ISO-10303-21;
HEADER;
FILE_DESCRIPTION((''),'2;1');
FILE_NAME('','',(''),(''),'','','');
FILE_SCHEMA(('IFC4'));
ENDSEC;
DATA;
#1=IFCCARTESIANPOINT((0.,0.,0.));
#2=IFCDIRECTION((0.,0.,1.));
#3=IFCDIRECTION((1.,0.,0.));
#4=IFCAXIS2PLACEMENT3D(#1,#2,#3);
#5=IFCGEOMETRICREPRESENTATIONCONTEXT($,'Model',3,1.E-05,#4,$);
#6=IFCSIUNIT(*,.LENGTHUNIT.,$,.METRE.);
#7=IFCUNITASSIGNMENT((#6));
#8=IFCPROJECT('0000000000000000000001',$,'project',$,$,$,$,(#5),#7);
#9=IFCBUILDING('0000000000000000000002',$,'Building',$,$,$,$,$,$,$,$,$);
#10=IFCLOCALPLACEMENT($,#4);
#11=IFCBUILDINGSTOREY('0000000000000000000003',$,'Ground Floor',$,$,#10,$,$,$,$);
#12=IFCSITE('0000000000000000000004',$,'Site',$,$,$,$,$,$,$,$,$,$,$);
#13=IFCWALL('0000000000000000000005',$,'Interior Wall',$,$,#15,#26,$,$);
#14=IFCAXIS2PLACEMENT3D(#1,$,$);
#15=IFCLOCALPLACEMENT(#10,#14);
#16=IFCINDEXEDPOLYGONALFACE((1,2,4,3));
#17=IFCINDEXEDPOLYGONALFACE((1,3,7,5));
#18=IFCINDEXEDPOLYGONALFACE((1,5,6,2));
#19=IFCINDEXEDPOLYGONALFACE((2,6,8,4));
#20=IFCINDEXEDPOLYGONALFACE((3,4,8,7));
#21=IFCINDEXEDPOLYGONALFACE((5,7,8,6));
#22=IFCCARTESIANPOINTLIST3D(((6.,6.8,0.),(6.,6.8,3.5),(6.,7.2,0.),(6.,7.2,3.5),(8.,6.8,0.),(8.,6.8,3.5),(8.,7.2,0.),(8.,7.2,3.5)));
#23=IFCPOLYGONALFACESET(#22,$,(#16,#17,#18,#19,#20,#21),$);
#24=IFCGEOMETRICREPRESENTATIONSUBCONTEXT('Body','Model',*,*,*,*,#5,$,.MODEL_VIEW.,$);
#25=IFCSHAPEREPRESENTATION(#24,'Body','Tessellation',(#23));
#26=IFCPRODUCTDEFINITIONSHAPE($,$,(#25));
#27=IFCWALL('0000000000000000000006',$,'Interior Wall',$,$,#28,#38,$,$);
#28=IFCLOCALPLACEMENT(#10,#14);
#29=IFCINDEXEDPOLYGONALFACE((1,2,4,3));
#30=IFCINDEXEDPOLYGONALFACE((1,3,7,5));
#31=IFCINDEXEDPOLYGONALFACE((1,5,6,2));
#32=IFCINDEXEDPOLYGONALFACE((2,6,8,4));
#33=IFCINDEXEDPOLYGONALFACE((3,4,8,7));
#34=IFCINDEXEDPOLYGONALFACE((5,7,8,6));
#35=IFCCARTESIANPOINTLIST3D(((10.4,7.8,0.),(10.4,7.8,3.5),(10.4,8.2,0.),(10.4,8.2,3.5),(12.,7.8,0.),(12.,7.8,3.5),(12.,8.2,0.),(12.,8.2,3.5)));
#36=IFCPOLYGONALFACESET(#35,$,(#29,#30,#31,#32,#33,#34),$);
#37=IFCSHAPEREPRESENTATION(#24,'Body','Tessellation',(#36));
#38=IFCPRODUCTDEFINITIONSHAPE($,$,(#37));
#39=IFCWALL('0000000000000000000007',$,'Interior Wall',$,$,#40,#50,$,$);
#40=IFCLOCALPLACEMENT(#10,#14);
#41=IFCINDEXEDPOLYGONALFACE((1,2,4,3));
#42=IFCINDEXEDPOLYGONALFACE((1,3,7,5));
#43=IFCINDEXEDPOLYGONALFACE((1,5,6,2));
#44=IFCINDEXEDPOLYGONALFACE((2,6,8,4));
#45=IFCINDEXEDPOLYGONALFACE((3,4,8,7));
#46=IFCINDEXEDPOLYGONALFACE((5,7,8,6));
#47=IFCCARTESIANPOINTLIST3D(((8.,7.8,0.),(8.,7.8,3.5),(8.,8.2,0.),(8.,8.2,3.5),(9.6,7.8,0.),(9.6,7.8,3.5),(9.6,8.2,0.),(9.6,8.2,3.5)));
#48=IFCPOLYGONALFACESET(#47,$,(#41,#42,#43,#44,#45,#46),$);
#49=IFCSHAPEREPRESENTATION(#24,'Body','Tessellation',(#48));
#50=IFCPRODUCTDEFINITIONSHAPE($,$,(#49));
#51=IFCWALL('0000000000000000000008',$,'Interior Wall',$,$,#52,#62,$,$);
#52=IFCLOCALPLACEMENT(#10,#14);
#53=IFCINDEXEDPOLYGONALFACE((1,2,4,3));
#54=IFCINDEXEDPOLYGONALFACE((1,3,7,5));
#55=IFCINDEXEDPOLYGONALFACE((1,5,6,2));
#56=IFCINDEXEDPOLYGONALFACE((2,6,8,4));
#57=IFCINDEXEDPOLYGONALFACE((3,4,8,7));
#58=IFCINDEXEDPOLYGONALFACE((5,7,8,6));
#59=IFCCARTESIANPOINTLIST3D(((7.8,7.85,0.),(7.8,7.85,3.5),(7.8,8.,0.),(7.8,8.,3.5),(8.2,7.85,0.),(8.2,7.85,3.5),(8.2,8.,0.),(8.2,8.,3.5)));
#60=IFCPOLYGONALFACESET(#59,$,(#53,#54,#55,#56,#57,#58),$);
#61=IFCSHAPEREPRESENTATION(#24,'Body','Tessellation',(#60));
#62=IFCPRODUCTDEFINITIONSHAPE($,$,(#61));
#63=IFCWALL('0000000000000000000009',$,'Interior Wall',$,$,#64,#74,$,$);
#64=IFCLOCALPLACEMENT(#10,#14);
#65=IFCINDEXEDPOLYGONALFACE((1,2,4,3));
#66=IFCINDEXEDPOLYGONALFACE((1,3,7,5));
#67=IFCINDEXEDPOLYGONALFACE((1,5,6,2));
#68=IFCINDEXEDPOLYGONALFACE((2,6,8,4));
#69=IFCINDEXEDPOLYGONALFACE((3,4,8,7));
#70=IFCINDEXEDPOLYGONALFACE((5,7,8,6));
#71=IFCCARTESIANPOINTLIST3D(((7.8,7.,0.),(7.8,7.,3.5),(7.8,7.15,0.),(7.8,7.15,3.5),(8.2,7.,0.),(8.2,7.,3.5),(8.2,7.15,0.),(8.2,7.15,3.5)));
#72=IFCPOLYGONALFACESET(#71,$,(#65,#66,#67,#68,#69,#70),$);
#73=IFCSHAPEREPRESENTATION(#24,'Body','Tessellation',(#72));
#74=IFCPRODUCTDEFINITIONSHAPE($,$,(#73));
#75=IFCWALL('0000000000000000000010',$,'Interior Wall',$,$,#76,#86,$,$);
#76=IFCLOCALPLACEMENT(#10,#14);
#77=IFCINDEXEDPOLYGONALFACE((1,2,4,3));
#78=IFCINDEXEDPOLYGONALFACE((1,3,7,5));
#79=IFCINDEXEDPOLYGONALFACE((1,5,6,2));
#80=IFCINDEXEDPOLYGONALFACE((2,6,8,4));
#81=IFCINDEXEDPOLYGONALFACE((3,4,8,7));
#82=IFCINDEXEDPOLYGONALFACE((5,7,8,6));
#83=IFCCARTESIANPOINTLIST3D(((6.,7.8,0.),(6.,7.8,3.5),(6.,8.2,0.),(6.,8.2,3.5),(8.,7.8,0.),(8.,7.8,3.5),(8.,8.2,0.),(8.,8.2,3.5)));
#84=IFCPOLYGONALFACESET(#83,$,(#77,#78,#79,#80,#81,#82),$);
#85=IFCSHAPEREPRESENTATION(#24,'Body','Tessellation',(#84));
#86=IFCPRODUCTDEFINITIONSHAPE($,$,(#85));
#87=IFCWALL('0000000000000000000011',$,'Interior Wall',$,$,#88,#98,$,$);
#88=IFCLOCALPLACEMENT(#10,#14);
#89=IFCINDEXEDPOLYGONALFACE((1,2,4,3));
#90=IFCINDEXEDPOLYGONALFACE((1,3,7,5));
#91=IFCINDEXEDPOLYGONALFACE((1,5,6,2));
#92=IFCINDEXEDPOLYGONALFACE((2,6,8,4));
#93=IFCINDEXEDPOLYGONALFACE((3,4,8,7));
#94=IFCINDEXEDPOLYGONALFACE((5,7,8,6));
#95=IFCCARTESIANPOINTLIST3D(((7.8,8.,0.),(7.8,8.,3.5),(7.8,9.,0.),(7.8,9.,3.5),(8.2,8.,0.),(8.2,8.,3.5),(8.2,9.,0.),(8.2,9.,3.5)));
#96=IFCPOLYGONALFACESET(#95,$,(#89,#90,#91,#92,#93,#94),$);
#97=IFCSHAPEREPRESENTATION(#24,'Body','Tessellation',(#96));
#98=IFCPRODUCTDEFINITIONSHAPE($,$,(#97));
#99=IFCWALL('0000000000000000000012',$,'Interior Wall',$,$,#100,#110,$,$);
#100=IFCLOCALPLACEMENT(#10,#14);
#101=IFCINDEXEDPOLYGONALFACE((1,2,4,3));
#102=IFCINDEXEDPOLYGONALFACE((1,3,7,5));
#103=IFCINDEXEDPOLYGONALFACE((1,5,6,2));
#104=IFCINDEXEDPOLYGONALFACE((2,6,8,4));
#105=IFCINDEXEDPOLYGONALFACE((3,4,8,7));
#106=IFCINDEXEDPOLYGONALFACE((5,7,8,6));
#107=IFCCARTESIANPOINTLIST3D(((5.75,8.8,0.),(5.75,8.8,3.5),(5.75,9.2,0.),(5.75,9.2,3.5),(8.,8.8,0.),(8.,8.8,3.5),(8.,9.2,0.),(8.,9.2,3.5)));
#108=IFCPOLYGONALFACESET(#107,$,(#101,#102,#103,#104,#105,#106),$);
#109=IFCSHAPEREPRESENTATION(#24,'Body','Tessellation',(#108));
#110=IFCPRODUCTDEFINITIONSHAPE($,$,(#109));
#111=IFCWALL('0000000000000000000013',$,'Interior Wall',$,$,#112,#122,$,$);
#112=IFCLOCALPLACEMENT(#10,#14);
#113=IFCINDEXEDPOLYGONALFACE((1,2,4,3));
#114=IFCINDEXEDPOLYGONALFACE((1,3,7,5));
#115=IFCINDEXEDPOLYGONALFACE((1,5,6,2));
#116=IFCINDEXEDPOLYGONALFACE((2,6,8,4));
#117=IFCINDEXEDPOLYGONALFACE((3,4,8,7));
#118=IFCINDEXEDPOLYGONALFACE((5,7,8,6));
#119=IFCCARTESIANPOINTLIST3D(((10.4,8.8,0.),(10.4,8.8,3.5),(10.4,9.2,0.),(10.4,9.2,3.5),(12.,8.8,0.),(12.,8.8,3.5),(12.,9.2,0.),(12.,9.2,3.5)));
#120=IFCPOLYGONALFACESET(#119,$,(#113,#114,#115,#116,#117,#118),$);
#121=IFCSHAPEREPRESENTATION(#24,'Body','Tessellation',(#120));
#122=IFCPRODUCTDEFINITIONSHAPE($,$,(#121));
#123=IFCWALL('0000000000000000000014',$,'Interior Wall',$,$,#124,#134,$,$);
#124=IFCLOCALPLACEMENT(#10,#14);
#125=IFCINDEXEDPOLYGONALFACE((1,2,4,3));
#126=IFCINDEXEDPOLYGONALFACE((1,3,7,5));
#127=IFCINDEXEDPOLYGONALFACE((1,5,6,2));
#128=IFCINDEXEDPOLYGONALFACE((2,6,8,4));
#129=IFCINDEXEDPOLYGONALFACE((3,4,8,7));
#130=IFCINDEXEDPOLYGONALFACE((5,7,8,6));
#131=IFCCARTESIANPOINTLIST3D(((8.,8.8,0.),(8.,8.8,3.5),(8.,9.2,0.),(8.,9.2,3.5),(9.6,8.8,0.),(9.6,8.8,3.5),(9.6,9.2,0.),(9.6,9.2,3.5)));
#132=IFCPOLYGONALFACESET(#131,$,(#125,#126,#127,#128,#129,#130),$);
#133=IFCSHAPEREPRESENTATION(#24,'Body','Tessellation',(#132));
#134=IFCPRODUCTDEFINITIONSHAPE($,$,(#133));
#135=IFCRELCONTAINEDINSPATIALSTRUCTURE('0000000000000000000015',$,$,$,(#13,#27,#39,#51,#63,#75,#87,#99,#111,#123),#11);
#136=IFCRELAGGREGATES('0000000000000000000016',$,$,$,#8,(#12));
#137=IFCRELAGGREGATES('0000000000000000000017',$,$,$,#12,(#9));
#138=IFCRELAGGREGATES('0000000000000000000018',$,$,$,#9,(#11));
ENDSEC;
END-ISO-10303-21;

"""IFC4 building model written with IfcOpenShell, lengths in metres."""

from ifc_helpers import new_model, si_unit, frame, origin_with_axes, place, context, subcontext, project, spatial, indexed_curve, outline, extrude, element, save


model = new_model("IFC4")

# Units and contexts
model_context = context("Model", 3, precision=1e-05, world=origin_with_axes())
body_context = subcontext(model_context, "Body", "Model", "MODEL_VIEW")
ifc_project = project(units=[si_unit("LENGTHUNIT", "METRE")], contexts=[model_context])

# Site, building, storey
site = spatial("IfcSite", under=ifc_project, Name="Site")
building = spatial("IfcBuilding", under=site, Name="Building")
storey_placement = place(None, origin_with_axes())
storey = spatial("IfcBuildingStorey", under=building, at=storey_placement, Name="Ground Floor")

# Walls
for number, where, z_axis, x_axis, name in (
    (1, (8.0, 7.0, 0.0), (0.0, 0.0, 1.0), (-1.0, 0.0, 0.0), "Interior Wall"),
):
    element("IfcWall", number, at=place(storey_placement, frame(where, z_axis=z_axis, x_axis=x_axis)), inside=storey, Name=name, context=body_context, shape_type="SweptSolid", body=[
        extrude(outline(indexed_curve([(0.0, 0.0), (0.0, 0.4), (2.0, 0.4), (2.0, 0.0), (0.0, 0.0)], self_intersect=False)), frame((0.0, -0.2, 0.0), z_axis=(0.0, 0.0, 1.0), x_axis=(1.0, 0.0, 0.0)), (0.0, 0.0, 1.0), 3.5),
    ])
for number, where, z_axis, x_axis, name in (
    (2, (12.0, 8.0, 0.0), (0.0, 0.0, 1.0), (-1.0, 0.0, 0.0), "Interior Wall"),
    (3, (9.6, 8.0, 0.0), (0.0, 0.0, 1.0), (-1.0, 0.0, 0.0), "Interior Wall"),
):
    element("IfcWall", number, at=place(storey_placement, frame(where, z_axis=z_axis, x_axis=x_axis)), inside=storey, Name=name, context=body_context, shape_type="SweptSolid", body=[
        extrude(outline(indexed_curve([(0.0, 0.0), (0.0, 0.4), (1.6, 0.4), (1.6, 0.0), (0.0, 0.0)], self_intersect=False)), frame((0.0, -0.2, 0.0), z_axis=(0.0, 0.0, 1.0), x_axis=(1.0, 0.0, 0.0)), (0.0, 0.0, 1.0), 3.5),
    ])
for number, where, z_axis, x_axis, name in (
    (4, (8.0, 8.0, 0.0), (0.0, 0.0, 1.0), (0.0, -1.0, 0.0), "Interior Wall"),
    (5, (8.0, 7.15, 0.0), (0.0, 0.0, 1.0), (0.0, -1.0, 0.0), "Interior Wall"),
):
    element("IfcWall", number, at=place(storey_placement, frame(where, z_axis=z_axis, x_axis=x_axis)), inside=storey, Name=name, context=body_context, shape_type="SweptSolid", body=[
        extrude(outline(indexed_curve([(0.0, 0.0), (0.0, 0.4), (0.15, 0.4), (0.15, 0.0), (0.0, 0.0)], self_intersect=False)), frame((0.0, -0.2, 0.0), z_axis=(0.0, 0.0, 1.0), x_axis=(1.0, 0.0, 0.0)), (0.0, 0.0, 1.0), 3.5),
    ])
wall_1_placement = place(storey_placement, frame((8.0, 8.0, 0.0), z_axis=(0.0, 0.0, 1.0), x_axis=(-1.0, 0.0, 0.0)))
element("IfcWall", 6, at=wall_1_placement, inside=storey, Name="Interior Wall", context=body_context, shape_type="SweptSolid", body=[
    extrude(outline(indexed_curve([(0.0, 0.0), (0.0, 0.4), (2.0, 0.4), (2.0, 0.0), (0.0, 0.0)], self_intersect=False)), frame((0.0, -0.2, 0.0), z_axis=(0.0, 0.0, 1.0), x_axis=(1.0, 0.0, 0.0)), (0.0, 0.0, 1.0), 3.5),
])
wall_2_placement = place(storey_placement, frame((8.0, 8.0, 0.0), z_axis=(0.0, 0.0, 1.0), x_axis=(0.0, 1.0, 0.0)))
element("IfcWall", 7, at=wall_2_placement, inside=storey, Name="Interior Wall", context=body_context, shape_type="SweptSolid", body=[
    extrude(outline(indexed_curve([(0.0, 0.0), (0.0, 0.4), (1.0, 0.4), (1.0, 0.0), (0.0, 0.0)], self_intersect=False)), frame((0.0, -0.2, 0.0), z_axis=(0.0, 0.0, 1.0), x_axis=(1.0, 0.0, 0.0)), (0.0, 0.0, 1.0), 3.5),
])
wall_3_placement = place(storey_placement, frame((8.0, 9.0, 0.0), z_axis=(0.0, 0.0, 1.0), x_axis=(-1.0, 0.0, 0.0)))
element("IfcWall", 8, at=wall_3_placement, inside=storey, Name="Interior Wall", context=body_context, shape_type="SweptSolid", body=[
    extrude(outline(indexed_curve([(0.0, 0.0), (0.0, 0.4), (2.25, 0.4), (2.25, 0.0), (0.0, 0.0)], self_intersect=False)), frame((0.0, -0.2, 0.0), z_axis=(0.0, 0.0, 1.0), x_axis=(1.0, 0.0, 0.0)), (0.0, 0.0, 1.0), 3.5),
])
for number, where, z_axis, x_axis, name in (
    (9, (12.0, 9.0, 0.0), (0.0, 0.0, 1.0), (-1.0, 0.0, 0.0), "Interior Wall"),
    (10, (9.6, 9.0, 0.0), (0.0, 0.0, 1.0), (-1.0, 0.0, 0.0), "Interior Wall"),
):
    element("IfcWall", number, at=place(storey_placement, frame(where, z_axis=z_axis, x_axis=x_axis)), inside=storey, Name=name, context=body_context, shape_type="SweptSolid", body=[
        extrude(outline(indexed_curve([(0.0, 0.0), (0.0, 0.4), (1.6, 0.4), (1.6, 0.0), (0.0, 0.0)], self_intersect=False)), frame((0.0, -0.2, 0.0), z_axis=(0.0, 0.0, 1.0), x_axis=(1.0, 0.0, 0.0)), (0.0, 0.0, 1.0), 3.5),
    ])

save(model, "model.ifc")
